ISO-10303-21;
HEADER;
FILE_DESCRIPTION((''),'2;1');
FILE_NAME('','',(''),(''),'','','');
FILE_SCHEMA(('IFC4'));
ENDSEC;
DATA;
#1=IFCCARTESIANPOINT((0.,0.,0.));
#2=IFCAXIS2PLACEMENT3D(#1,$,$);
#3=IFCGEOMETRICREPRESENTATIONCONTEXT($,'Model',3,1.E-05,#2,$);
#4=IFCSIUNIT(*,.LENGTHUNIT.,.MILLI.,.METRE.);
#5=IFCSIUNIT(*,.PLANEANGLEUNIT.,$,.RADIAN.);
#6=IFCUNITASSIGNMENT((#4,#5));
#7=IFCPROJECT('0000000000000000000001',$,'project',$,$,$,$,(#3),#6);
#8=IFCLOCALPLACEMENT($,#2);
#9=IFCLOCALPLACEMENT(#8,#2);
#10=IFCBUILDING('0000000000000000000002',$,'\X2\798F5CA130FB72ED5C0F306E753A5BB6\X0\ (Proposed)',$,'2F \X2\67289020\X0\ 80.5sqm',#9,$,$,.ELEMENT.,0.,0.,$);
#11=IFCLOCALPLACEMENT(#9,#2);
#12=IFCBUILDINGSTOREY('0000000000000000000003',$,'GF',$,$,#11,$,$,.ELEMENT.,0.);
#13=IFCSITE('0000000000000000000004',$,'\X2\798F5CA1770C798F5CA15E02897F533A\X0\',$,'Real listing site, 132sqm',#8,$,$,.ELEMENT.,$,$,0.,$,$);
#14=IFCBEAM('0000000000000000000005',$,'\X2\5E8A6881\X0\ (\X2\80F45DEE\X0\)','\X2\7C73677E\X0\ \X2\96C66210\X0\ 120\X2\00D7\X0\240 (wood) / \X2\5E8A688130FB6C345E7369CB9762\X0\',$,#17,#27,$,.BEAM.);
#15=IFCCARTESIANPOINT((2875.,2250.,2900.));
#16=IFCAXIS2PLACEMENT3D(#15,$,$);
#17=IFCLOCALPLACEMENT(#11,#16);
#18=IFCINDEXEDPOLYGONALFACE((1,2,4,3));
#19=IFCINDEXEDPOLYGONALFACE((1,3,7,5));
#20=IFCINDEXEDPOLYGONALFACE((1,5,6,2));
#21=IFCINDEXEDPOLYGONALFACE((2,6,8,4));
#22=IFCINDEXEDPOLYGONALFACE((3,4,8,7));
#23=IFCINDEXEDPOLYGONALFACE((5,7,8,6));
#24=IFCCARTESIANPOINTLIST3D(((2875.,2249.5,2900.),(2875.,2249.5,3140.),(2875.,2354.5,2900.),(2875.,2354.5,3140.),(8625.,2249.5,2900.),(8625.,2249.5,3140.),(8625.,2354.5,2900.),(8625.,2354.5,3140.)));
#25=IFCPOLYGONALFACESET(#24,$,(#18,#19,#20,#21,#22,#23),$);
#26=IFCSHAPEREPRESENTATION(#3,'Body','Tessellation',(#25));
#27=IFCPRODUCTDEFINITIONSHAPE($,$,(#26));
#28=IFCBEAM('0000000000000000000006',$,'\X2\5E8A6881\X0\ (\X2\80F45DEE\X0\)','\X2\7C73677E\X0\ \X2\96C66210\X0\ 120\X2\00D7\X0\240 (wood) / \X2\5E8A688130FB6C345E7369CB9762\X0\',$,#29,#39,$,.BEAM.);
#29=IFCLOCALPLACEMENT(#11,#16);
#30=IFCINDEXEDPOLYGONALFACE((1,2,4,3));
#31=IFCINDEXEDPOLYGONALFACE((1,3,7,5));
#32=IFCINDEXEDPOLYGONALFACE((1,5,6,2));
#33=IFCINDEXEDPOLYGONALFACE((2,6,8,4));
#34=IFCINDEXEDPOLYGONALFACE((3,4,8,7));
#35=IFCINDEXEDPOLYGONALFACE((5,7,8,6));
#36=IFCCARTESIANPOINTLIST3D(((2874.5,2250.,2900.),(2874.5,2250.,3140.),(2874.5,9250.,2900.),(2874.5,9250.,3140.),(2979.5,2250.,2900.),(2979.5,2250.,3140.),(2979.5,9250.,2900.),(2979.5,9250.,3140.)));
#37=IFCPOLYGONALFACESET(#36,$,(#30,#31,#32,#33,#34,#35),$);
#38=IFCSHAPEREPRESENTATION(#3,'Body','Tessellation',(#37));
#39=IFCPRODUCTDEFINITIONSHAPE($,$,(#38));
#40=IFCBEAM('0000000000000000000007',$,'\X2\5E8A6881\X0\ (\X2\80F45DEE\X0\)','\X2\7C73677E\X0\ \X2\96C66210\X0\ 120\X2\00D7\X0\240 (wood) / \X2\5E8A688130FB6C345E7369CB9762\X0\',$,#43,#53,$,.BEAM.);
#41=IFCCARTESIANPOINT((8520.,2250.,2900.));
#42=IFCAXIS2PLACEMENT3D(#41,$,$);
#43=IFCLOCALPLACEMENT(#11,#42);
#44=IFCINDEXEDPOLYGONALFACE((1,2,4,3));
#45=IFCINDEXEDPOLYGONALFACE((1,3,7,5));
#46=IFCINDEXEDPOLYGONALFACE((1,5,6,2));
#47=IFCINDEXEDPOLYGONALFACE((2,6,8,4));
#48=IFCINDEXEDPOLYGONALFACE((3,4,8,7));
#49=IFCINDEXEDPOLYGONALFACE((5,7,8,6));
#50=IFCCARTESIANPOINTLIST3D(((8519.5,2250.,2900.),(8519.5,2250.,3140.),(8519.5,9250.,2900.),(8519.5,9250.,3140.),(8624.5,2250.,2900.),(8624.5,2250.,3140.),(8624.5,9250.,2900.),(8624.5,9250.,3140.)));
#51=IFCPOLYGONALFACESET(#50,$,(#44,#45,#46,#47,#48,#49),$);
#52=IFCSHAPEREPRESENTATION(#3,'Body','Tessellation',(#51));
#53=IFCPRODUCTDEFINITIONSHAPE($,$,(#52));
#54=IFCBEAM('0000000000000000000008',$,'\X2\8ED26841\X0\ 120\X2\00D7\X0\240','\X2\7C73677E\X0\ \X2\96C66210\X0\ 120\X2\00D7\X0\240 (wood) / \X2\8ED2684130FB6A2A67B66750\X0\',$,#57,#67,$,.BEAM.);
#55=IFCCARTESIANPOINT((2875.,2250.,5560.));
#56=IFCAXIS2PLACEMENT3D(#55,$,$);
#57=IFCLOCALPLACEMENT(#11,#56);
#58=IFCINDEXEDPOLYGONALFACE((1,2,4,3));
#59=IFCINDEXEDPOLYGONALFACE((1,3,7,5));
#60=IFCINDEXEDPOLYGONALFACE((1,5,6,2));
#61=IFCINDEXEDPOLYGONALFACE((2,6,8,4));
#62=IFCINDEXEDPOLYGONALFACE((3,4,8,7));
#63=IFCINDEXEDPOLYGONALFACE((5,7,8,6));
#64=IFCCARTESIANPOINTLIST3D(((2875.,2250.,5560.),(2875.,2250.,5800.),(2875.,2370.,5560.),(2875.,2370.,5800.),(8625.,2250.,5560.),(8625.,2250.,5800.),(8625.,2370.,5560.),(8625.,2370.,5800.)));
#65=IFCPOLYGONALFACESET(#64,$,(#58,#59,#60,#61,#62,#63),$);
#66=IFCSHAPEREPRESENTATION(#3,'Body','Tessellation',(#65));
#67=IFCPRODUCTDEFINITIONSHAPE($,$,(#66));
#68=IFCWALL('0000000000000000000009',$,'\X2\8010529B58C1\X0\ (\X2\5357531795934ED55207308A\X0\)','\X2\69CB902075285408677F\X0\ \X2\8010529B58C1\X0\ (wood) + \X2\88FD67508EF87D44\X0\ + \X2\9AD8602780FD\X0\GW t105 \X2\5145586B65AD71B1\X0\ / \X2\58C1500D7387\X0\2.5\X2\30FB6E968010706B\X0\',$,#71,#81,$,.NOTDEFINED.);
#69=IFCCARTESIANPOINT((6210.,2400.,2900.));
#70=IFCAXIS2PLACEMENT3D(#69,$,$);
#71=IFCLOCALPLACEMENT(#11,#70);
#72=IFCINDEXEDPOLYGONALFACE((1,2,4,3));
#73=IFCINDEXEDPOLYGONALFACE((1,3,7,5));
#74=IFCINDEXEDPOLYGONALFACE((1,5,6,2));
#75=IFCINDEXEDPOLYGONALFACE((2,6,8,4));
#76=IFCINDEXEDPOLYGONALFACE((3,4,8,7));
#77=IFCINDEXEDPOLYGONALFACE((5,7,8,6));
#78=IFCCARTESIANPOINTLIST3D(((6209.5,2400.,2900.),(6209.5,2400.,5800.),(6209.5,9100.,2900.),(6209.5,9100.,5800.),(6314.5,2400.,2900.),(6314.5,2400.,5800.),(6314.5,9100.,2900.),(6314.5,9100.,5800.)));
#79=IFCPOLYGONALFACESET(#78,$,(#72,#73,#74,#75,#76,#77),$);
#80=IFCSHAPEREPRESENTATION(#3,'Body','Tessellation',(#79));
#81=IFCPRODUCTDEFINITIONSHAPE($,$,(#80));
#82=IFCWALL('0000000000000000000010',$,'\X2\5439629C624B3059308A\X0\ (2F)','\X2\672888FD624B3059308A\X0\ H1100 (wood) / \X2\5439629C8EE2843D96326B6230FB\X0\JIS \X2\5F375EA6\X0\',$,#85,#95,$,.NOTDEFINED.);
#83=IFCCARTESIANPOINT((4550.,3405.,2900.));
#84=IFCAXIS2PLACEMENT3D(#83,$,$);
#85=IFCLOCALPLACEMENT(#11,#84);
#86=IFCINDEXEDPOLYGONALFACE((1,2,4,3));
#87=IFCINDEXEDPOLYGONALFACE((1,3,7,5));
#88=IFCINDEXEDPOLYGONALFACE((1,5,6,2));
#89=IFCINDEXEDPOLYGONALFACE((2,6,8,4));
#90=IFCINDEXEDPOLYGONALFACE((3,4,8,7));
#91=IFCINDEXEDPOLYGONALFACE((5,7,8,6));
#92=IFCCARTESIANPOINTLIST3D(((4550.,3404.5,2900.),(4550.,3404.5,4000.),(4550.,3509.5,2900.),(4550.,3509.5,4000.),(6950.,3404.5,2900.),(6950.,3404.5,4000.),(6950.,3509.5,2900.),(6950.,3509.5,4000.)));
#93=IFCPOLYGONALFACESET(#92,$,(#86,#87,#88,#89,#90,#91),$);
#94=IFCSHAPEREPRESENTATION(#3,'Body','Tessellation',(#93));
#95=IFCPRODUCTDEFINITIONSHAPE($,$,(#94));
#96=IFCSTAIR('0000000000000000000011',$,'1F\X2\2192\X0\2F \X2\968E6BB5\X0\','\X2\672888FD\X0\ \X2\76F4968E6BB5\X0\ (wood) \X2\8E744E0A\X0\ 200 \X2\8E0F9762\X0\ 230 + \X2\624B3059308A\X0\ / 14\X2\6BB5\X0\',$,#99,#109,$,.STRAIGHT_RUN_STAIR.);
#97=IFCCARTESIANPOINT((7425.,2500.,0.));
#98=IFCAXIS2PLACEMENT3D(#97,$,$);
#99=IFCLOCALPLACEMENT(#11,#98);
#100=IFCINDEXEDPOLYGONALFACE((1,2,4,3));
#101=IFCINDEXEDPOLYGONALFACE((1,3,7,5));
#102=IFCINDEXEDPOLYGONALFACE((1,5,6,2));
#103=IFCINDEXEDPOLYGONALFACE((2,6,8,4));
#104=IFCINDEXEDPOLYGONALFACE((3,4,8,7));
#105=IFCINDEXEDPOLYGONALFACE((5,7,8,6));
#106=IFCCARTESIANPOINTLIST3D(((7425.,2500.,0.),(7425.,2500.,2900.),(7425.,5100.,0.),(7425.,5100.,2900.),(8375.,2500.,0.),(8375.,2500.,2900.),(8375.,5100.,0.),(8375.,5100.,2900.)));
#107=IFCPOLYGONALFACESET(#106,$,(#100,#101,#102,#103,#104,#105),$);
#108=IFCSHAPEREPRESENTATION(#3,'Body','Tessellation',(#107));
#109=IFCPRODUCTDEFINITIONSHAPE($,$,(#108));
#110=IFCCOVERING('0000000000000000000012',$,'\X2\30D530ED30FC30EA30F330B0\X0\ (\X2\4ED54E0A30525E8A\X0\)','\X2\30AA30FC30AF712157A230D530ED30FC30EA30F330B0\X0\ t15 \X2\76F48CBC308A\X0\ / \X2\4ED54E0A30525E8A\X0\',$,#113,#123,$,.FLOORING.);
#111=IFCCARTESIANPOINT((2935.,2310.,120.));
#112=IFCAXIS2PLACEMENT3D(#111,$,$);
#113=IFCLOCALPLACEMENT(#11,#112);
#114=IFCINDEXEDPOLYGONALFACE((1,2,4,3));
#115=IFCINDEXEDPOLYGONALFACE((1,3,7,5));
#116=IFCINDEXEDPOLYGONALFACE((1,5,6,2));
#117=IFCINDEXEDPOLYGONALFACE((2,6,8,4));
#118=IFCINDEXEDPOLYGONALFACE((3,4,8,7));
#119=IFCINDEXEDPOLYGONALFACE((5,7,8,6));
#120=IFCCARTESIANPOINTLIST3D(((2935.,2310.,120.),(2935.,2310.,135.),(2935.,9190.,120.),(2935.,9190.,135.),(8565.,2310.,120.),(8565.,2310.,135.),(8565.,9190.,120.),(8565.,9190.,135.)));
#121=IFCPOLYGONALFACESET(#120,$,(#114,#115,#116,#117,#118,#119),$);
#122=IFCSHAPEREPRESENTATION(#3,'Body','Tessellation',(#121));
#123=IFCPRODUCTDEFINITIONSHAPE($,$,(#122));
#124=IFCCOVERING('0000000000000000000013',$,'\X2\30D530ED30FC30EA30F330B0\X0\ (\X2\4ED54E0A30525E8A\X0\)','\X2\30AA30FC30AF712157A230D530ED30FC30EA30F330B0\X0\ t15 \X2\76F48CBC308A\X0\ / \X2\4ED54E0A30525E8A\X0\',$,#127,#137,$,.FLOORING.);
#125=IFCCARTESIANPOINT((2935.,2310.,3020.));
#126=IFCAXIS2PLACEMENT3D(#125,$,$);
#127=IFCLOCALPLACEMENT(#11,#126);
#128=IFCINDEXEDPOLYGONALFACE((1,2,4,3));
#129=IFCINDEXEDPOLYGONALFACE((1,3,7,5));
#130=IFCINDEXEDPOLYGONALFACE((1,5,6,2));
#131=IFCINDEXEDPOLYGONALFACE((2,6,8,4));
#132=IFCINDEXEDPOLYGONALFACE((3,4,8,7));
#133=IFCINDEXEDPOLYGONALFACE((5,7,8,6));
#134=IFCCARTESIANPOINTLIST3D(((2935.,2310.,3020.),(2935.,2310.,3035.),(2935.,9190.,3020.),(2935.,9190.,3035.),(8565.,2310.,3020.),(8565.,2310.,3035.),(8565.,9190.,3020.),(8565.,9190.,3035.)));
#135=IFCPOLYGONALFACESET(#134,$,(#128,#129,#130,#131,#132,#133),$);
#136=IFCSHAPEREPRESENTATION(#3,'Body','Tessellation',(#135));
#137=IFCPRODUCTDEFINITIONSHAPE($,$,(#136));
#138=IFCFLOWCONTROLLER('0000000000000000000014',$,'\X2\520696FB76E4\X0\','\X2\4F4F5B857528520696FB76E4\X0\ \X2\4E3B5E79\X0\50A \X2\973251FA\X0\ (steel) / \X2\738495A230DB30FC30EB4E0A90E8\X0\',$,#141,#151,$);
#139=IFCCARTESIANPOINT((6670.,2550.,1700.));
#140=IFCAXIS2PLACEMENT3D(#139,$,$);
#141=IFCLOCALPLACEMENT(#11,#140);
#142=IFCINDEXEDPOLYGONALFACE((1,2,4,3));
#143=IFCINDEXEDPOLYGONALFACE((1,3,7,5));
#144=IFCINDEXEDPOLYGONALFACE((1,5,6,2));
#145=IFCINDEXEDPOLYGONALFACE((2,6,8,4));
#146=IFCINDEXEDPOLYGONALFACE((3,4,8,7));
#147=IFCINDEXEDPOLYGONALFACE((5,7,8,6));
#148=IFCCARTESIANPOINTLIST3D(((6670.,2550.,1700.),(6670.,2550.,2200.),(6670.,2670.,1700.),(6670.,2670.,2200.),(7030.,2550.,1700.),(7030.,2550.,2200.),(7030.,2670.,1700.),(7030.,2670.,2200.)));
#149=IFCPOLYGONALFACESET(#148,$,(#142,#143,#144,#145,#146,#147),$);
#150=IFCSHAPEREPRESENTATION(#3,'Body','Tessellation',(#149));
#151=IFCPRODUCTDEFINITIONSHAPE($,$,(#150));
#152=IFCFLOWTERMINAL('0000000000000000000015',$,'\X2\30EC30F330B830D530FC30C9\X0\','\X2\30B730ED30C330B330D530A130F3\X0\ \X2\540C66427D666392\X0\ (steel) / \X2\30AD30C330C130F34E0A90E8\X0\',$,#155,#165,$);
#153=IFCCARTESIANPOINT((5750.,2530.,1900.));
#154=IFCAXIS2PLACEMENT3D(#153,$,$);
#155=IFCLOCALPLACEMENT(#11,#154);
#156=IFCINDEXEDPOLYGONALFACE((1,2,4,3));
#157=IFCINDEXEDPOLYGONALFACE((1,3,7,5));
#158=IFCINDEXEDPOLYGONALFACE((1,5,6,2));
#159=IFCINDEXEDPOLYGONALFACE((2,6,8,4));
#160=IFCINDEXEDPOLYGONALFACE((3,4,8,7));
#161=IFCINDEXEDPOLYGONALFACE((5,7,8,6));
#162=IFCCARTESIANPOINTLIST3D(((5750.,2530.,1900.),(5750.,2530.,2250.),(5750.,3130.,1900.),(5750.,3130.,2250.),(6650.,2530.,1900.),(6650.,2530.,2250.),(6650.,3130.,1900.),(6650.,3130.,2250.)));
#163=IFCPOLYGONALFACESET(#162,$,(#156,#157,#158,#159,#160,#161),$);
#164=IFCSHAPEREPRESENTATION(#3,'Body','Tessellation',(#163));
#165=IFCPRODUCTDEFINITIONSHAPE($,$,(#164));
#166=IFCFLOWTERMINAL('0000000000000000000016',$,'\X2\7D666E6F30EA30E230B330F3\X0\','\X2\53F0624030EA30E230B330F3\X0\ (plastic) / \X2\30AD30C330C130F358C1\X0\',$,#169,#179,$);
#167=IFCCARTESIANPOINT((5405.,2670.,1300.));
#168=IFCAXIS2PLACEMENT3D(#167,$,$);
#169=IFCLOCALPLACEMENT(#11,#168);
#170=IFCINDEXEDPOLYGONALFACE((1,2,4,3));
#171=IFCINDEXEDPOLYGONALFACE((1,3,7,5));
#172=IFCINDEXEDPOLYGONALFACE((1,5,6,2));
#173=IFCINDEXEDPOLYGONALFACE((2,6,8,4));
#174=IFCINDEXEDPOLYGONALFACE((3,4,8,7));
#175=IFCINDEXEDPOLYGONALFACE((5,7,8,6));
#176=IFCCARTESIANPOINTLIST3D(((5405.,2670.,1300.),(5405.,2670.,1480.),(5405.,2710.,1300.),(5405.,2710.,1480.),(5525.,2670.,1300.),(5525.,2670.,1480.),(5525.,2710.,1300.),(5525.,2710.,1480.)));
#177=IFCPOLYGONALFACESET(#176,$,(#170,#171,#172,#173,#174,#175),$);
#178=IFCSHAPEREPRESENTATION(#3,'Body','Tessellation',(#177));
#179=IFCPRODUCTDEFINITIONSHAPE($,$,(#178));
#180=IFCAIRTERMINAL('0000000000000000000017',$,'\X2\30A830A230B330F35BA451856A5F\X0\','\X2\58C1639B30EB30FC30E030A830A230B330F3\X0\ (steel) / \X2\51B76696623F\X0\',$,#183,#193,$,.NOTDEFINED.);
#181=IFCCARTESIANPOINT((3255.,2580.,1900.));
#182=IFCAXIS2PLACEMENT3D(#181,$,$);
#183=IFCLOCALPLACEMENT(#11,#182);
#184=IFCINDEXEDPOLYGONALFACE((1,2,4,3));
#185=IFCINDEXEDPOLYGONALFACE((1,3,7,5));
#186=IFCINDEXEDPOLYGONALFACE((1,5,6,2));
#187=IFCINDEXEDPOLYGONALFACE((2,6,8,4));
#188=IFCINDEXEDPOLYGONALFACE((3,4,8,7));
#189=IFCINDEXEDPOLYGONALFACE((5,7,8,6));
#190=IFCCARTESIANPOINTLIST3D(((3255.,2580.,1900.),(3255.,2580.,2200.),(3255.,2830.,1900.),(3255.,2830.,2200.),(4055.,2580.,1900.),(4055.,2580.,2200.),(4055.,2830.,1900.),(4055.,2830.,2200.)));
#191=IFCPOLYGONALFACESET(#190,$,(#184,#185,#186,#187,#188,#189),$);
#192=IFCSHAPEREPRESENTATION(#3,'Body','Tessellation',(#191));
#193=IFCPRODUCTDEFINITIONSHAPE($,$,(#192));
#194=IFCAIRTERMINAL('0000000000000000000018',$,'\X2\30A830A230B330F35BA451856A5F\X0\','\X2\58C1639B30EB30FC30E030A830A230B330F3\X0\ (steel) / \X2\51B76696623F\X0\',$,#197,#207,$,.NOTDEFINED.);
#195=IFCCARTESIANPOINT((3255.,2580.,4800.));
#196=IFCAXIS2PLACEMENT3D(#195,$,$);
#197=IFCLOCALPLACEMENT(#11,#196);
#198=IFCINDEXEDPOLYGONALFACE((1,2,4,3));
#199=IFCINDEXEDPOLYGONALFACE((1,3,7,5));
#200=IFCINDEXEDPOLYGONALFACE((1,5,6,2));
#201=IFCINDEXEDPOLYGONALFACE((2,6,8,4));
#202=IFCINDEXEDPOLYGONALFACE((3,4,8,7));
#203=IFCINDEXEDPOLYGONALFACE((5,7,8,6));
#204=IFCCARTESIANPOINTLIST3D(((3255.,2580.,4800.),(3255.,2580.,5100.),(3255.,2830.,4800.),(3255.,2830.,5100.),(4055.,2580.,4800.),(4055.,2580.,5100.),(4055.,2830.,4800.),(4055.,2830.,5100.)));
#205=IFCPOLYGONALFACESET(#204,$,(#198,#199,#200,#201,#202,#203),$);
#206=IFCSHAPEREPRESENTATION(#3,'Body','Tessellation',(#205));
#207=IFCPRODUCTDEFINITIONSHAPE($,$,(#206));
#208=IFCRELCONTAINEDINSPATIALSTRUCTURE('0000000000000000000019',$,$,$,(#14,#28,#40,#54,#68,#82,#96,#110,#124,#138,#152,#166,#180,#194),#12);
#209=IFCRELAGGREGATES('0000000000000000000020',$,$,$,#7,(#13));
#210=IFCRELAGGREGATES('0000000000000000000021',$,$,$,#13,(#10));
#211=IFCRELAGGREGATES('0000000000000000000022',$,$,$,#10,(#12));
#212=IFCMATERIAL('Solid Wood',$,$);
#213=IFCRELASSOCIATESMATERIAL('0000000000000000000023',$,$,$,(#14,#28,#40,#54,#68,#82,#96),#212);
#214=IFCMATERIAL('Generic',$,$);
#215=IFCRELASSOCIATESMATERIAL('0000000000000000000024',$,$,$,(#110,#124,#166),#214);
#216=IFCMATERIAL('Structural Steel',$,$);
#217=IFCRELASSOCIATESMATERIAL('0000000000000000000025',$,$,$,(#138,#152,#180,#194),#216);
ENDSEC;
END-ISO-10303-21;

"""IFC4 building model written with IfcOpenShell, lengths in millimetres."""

from ifc_helpers import new_model, si_unit, frame, frame_2d, origin, place, context, project, spatial, rectangle, extrude, material, element, save


model = new_model("IFC4")

# Units and contexts
model_context = context("Model", 3, precision=1e-05, world=origin())
ifc_project = project(units=[si_unit("LENGTHUNIT", "METRE", prefix="MILLI"), si_unit("PLANEANGLEUNIT", "RADIAN")], contexts=[model_context])

# Site, building, storey
site_placement = place(None, origin())
site = spatial("IfcSite", under=ifc_project, at=site_placement, Name="福岡県福岡市西区", ObjectType="Real listing site, 132sqm", CompositionType="ELEMENT", RefElevation=0.0)
building_placement = place(site_placement, origin())
building = spatial("IfcBuilding", under=site, at=building_placement, Name="福岡・狭小の町家 (Proposed)", ObjectType="2F 木造 80.5sqm", CompositionType="ELEMENT", ElevationOfRefHeight=0.0, ElevationOfTerrain=0.0)
storey_placement = place(building_placement, origin())
storey = spatial("IfcBuildingStorey", under=building, at=storey_placement, Name="GF", CompositionType="ELEMENT", Elevation=0.0)

# Shared definitions
ifc_material_1 = material(Name="Solid Wood")

# Beams
beam_1_placement = place(storey_placement, frame((2875.0, 2250.0, 2900.0)))
element("IfcBeam", 1, at=beam_1_placement, inside=storey, material=ifc_material_1, Name="床梁 (胴差)", Description="米松 集成 120×240 (wood) / 床梁・水平構面", PredefinedType="BEAM", context=model_context, shape_type="SweptSolid", body=[
    extrude(rectangle(XDim=5750.0, YDim=105.0, at=frame_2d((2875.0, 52.0))), frame((2875.0, 2250.0, 2900.0)), (0.0, 0.0, 1.0), 240.0),
])
beam_2_placement = place(storey_placement, frame((2875.0, 2250.0, 2900.0)))
element("IfcBeam", 2, at=beam_2_placement, inside=storey, material=ifc_material_1, Name="床梁 (胴差)", Description="米松 集成 120×240 (wood) / 床梁・水平構面", PredefinedType="BEAM", context=model_context, shape_type="SweptSolid", body=[
    extrude(rectangle(XDim=105.0, YDim=7000.0, at=frame_2d((52.0, 3500.0))), frame((2875.0, 2250.0, 2900.0)), (0.0, 0.0, 1.0), 240.0),
])
beam_3_placement = place(storey_placement, frame((8520.0, 2250.0, 2900.0)))
element("IfcBeam", 3, at=beam_3_placement, inside=storey, material=ifc_material_1, Name="床梁 (胴差)", Description="米松 集成 120×240 (wood) / 床梁・水平構面", PredefinedType="BEAM", context=model_context, shape_type="SweptSolid", body=[
    extrude(rectangle(XDim=105.0, YDim=7000.0, at=frame_2d((52.0, 3500.0))), frame((8520.0, 2250.0, 2900.0)), (0.0, 0.0, 1.0), 240.0),
])
beam_4_placement = place(storey_placement, frame((2875.0, 2250.0, 5560.0)))
element("IfcBeam", 4, at=beam_4_placement, inside=storey, material=ifc_material_1, Name="軒桁 120×240", Description="米松 集成 120×240 (wood) / 軒桁・横架材", PredefinedType="BEAM", context=model_context, shape_type="SweptSolid", body=[
    extrude(rectangle(XDim=5750.0, YDim=120.0, at=frame_2d((2875.0, 60.0))), frame((2875.0, 2250.0, 5560.0)), (0.0, 0.0, 1.0), 240.0),
])

# Walls
wall_1_placement = place(storey_placement, frame((6210.0, 2400.0, 2900.0)))
element("IfcWall", 5, at=wall_1_placement, inside=storey, material=ifc_material_1, Name="耐力壁 (南北間仕切り)", Description="構造用合板 耐力壁 (wood) + 製材軸組 + 高性能GW t105 充填断熱 / 壁倍率2.5・準耐火", PredefinedType="NOTDEFINED", context=model_context, shape_type="SweptSolid", body=[
    extrude(rectangle(XDim=105.0, YDim=6700.0, at=frame_2d((52.0, 3350.0))), frame((6210.0, 2400.0, 2900.0)), (0.0, 0.0, 1.0), 2900.0),
])
wall_2_placement = place(storey_placement, frame((4550.0, 3405.0, 2900.0)))
element("IfcWall", 6, at=wall_2_placement, inside=storey, material=ifc_material_1, Name="吹抜手すり (2F)", Description="木製手すり H1100 (wood) / 吹抜転落防止・JIS 強度", PredefinedType="NOTDEFINED", context=model_context, shape_type="SweptSolid", body=[
    extrude(rectangle(XDim=2400.0, YDim=105.0, at=frame_2d((1200.0, 52.0))), frame((4550.0, 3405.0, 2900.0)), (0.0, 0.0, 1.0), 1100.0),
])

# Stair
stair_placement = place(storey_placement, frame((7425.0, 2500.0, 0.0)))
element("IfcStair", 7, at=stair_placement, inside=storey, material=ifc_material_1, Name="1F→2F 階段", Description="木製 直階段 (wood) 蹴上 200 踏面 230 + 手すり / 14段", PredefinedType="STRAIGHT_RUN_STAIR", context=model_context, shape_type="SweptSolid", body=[
    extrude(rectangle(XDim=950.0, YDim=2600.0, at=frame_2d((475.0, 1300.0))), frame((7425.0, 2500.0, 0.0)), (0.0, 0.0, 1.0), 2900.0),
])

# Coverings
ifc_material_2 = material(Name="Generic")
covering_1_placement = place(storey_placement, frame((2935.0, 2310.0, 120.0)))
element("IfcCovering", 8, at=covering_1_placement, inside=storey, material=ifc_material_2, Name="フローリング (仕上げ床)", Description="オーク無垢フローリング t15 直貼り / 仕上げ床", PredefinedType="FLOORING", context=model_context, shape_type="SweptSolid", body=[
    extrude(rectangle(XDim=5630.0, YDim=6880.0, at=frame_2d((2815.0, 3440.0))), frame((2935.0, 2310.0, 120.0)), (0.0, 0.0, 1.0), 15.0),
])
covering_2_placement = place(storey_placement, frame((2935.0, 2310.0, 3020.0)))
element("IfcCovering", 9, at=covering_2_placement, inside=storey, material=ifc_material_2, Name="フローリング (仕上げ床)", Description="オーク無垢フローリング t15 直貼り / 仕上げ床", PredefinedType="FLOORING", context=model_context, shape_type="SweptSolid", body=[
    extrude(rectangle(XDim=5630.0, YDim=6880.0, at=frame_2d((2815.0, 3440.0))), frame((2935.0, 2310.0, 3020.0)), (0.0, 0.0, 1.0), 15.0),
])

# Flow controller
ifc_material_3 = material(Name="Structural Steel")
flow_controller_placement = place(storey_placement, frame((6670.0, 2550.0, 1700.0)))
element("IfcFlowController", 10, at=flow_controller_placement, inside=storey, material=ifc_material_3, Name="分電盤", Description="住宅用分電盤 主幹50A 露出 (steel) / 玄関ホール上部", context=model_context, shape_type="SweptSolid", body=[
    extrude(rectangle(XDim=360.0, YDim=120.0, at=frame_2d((180.0, 60.0))), frame((6670.0, 2550.0, 1700.0)), (0.0, 0.0, 1.0), 500.0),
])

# Flow terminals
flow_terminal_1_placement = place(storey_placement, frame((5750.0, 2530.0, 1900.0)))
element("IfcFlowTerminal", 11, at=flow_terminal_1_placement, inside=storey, material=ifc_material_3, Name="レンジフード", Description="シロッコファン 同時給排 (steel) / キッチン上部", context=model_context, shape_type="SweptSolid", body=[
    extrude(rectangle(XDim=900.0, YDim=600.0, at=frame_2d((450.0, 300.0))), frame((5750.0, 2530.0, 1900.0)), (0.0, 0.0, 1.0), 350.0),
])
flow_terminal_2_placement = place(storey_placement, frame((5405.0, 2670.0, 1300.0)))
element("IfcFlowTerminal", 12, at=flow_terminal_2_placement, inside=storey, material=ifc_material_2, Name="給湯リモコン", Description="台所リモコン (plastic) / キッチン壁", context=model_context, shape_type="SweptSolid", body=[
    extrude(rectangle(XDim=120.0, YDim=40.0, at=frame_2d((60.0, 20.0))), frame((5405.0, 2670.0, 1300.0)), (0.0, 0.0, 1.0), 180.0),
])

# Air terminals
air_terminal_1_placement = place(storey_placement, frame((3255.0, 2580.0, 1900.0)))
element("IfcAirTerminal", 13, at=air_terminal_1_placement, inside=storey, material=ifc_material_3, Name="エアコン室内機", Description="壁掛ルームエアコン (steel) / 冷暖房", PredefinedType="NOTDEFINED", context=model_context, shape_type="SweptSolid", body=[
    extrude(rectangle(XDim=800.0, YDim=250.0, at=frame_2d((400.0, 125.0))), frame((3255.0, 2580.0, 1900.0)), (0.0, 0.0, 1.0), 300.0),
])
air_terminal_2_placement = place(storey_placement, frame((3255.0, 2580.0, 4800.0)))
element("IfcAirTerminal", 14, at=air_terminal_2_placement, inside=storey, material=ifc_material_3, Name="エアコン室内機", Description="壁掛ルームエアコン (steel) / 冷暖房", PredefinedType="NOTDEFINED", context=model_context, shape_type="SweptSolid", body=[
    extrude(rectangle(XDim=800.0, YDim=250.0, at=frame_2d((400.0, 125.0))), frame((3255.0, 2580.0, 4800.0)), (0.0, 0.0, 1.0), 300.0),
])

save(model, "model.ifc")
